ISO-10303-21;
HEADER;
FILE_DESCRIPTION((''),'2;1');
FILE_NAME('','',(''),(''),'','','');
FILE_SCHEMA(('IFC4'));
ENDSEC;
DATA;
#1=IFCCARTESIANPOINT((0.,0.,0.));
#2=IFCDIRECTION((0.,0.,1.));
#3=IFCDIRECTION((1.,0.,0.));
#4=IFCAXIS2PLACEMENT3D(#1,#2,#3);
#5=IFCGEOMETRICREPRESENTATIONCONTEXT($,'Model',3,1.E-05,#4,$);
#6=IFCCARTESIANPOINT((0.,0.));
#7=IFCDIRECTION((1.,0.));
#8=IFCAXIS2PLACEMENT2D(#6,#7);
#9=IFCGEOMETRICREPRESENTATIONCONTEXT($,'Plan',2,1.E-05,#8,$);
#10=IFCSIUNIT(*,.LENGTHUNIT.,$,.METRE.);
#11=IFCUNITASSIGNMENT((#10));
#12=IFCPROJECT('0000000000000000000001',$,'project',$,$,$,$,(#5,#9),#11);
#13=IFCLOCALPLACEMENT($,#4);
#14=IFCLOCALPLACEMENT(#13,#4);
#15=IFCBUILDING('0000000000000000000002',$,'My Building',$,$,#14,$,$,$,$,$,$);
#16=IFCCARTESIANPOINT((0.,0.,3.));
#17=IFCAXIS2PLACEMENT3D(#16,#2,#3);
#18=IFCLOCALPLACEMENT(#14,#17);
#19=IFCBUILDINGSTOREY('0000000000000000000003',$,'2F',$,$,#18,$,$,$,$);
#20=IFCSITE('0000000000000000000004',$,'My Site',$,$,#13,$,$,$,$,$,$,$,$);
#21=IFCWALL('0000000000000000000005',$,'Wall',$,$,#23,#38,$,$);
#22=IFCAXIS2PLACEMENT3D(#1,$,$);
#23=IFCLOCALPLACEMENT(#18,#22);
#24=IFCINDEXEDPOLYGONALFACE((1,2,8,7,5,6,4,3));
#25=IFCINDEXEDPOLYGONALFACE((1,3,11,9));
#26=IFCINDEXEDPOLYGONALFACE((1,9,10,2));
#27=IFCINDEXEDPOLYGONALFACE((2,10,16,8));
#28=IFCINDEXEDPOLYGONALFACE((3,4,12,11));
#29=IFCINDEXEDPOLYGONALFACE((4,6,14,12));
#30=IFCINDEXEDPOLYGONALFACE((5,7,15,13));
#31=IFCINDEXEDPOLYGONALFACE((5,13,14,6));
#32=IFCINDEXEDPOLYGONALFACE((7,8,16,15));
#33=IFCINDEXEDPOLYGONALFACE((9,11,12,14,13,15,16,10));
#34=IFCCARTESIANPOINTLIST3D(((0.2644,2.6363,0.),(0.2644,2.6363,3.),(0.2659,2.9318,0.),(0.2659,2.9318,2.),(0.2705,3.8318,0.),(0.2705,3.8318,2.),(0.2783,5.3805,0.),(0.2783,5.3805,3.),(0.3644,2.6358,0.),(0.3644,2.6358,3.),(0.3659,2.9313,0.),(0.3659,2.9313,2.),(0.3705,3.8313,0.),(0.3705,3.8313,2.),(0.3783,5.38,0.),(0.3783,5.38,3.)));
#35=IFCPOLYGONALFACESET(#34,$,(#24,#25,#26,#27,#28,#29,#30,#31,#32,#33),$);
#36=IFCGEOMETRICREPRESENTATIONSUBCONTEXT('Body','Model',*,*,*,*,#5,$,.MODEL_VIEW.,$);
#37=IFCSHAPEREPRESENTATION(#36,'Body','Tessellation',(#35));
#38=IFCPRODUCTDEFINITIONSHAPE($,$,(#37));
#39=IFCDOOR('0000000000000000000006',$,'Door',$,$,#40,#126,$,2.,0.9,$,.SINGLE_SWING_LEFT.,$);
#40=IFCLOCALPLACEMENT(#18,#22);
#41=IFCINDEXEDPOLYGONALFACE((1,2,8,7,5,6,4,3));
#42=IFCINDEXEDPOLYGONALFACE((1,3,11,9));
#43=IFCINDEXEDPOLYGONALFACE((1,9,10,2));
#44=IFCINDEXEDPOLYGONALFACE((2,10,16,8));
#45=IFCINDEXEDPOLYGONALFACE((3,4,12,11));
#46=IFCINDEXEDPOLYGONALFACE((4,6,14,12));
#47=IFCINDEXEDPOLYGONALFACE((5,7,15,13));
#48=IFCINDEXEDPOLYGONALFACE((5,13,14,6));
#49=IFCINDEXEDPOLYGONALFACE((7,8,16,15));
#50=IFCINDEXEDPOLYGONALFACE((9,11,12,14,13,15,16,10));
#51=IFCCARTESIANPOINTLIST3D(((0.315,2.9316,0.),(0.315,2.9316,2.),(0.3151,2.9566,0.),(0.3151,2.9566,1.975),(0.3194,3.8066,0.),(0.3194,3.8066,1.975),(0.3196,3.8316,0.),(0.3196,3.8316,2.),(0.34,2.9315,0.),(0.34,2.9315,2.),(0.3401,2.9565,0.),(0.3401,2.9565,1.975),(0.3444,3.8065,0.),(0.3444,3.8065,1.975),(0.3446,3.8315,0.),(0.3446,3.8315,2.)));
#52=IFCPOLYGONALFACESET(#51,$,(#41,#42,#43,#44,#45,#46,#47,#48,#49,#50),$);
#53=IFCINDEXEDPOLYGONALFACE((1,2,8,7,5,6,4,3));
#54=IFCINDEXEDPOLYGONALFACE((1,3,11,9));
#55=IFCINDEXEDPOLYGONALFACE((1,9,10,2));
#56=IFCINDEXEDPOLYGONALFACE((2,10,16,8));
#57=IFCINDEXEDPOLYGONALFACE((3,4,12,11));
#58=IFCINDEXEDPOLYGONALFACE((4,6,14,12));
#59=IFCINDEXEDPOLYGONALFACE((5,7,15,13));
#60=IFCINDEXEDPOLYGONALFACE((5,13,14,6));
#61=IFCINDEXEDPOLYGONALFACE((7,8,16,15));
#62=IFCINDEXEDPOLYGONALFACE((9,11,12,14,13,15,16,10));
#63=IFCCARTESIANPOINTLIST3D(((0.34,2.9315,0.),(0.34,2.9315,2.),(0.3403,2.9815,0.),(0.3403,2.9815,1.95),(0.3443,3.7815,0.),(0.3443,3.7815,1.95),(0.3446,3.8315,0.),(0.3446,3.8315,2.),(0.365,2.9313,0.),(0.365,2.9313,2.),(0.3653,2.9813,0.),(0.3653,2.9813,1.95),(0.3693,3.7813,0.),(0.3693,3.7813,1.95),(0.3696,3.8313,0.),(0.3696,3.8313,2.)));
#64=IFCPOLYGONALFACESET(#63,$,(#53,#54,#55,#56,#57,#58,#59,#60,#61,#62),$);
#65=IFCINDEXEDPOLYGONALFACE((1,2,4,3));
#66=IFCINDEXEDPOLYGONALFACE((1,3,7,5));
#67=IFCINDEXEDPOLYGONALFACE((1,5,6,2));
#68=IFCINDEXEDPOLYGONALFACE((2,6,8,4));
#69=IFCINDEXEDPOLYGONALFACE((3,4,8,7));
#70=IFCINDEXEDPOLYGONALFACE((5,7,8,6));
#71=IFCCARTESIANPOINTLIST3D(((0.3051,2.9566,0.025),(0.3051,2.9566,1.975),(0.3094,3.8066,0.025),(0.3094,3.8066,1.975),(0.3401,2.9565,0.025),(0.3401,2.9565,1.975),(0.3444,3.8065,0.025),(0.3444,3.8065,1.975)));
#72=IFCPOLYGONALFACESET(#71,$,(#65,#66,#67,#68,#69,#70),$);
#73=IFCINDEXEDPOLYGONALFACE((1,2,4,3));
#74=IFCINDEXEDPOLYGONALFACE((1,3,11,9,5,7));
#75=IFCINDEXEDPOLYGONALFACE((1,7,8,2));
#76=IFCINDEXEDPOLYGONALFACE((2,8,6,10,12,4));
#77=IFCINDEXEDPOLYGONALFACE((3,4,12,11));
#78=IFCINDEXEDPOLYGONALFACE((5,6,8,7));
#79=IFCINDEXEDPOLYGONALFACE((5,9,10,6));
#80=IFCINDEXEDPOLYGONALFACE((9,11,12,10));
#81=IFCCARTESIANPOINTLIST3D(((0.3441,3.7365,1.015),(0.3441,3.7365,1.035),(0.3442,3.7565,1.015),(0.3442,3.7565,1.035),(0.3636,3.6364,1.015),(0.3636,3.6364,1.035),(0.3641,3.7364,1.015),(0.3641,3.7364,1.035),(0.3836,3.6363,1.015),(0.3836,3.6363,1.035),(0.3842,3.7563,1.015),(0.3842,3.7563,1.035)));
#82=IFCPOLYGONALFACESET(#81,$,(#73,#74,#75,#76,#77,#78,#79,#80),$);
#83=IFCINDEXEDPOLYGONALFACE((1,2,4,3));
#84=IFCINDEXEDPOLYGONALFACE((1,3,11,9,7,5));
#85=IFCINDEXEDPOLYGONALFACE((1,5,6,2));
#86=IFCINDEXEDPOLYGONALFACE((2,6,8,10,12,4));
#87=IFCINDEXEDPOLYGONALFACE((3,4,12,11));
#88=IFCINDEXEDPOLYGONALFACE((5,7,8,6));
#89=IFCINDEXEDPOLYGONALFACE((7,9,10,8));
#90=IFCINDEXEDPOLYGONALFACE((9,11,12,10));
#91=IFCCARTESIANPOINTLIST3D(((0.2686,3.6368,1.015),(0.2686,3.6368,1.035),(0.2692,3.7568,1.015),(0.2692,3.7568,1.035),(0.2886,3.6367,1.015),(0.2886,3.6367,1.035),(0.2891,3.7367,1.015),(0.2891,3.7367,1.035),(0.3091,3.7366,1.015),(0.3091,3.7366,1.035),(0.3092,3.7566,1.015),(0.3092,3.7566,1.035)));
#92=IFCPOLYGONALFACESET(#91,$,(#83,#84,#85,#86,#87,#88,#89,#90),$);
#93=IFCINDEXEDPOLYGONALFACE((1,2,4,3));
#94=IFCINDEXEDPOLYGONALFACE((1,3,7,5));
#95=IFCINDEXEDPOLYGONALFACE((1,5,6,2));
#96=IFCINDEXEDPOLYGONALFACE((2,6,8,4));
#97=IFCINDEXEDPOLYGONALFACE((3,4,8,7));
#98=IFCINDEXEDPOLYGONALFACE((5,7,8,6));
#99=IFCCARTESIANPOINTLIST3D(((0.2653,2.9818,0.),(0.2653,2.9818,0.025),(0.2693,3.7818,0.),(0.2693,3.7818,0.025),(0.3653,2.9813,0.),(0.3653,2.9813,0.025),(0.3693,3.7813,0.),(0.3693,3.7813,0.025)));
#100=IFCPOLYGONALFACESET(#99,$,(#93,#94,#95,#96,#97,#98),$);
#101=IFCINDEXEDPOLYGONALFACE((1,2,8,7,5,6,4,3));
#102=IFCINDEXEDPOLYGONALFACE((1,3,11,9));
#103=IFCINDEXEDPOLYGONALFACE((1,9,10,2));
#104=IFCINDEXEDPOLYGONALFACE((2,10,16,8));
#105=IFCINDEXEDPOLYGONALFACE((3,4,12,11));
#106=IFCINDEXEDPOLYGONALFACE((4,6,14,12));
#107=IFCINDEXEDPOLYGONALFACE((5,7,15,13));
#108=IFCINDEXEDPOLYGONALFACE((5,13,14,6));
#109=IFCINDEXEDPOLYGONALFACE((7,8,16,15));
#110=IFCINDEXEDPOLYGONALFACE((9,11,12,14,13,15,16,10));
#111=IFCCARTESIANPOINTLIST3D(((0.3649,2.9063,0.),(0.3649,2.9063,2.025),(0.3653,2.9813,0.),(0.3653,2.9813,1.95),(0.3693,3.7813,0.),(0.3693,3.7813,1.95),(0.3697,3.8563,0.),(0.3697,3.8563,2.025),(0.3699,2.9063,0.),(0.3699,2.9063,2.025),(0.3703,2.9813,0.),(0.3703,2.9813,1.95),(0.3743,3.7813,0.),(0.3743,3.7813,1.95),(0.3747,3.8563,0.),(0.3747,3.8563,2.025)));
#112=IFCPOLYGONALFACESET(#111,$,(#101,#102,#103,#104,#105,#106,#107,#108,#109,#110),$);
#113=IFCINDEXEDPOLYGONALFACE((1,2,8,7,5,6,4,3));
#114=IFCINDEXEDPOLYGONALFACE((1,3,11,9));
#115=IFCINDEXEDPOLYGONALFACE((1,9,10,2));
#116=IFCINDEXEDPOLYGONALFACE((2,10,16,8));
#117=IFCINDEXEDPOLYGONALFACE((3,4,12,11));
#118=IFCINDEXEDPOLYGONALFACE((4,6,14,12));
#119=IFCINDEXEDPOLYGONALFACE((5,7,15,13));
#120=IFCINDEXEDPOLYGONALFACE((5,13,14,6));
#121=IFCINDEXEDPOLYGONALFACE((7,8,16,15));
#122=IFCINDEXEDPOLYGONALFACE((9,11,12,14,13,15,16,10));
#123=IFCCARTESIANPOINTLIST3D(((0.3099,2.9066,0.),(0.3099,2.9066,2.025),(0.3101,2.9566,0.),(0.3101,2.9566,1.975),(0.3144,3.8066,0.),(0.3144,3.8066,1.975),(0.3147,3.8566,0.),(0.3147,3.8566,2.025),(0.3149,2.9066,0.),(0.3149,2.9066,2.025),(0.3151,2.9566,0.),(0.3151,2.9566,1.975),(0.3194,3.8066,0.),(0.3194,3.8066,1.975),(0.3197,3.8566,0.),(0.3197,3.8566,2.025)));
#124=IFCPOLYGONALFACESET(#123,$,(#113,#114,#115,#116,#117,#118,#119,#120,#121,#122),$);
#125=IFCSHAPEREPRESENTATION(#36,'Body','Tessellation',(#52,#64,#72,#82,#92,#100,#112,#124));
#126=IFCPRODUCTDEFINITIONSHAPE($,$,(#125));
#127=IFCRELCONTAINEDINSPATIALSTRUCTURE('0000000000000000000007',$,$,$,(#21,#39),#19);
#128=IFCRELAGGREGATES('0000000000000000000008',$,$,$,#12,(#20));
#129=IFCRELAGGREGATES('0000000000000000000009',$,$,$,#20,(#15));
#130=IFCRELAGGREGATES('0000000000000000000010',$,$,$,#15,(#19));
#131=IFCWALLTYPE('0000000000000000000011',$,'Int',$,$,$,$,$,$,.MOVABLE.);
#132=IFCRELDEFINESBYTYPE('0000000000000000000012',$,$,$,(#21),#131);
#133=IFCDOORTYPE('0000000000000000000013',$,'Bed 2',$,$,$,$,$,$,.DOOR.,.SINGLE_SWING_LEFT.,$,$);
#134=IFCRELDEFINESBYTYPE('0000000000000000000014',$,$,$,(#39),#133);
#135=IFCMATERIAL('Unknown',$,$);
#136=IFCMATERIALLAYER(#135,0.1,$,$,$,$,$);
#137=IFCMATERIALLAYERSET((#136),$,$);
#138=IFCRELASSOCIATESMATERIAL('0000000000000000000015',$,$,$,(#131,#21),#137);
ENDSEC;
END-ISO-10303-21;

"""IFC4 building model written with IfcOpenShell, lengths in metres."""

from ifc_helpers import new_model, entity, si_unit, frame, origin_with_axes, origin_2d_with_axis, place, context, subcontext, project, spatial, line, indexed_curve, outline, extrude, shape, source, transform, mapped, material, layer, layer_set, layer_usage, type_object, type_shapes, element, fill, save


model = new_model("IFC4")

# Units and contexts
model_context = context("Model", 3, precision=1e-05, world=origin_with_axes())
plan_context = context("Plan", 2, precision=1e-05, world=origin_2d_with_axis())
body_context_1 = subcontext(model_context, "Body", "Model", "MODEL_VIEW")
body_context_2 = subcontext(plan_context, "Body", "Plan", "PLAN_VIEW")
ifc_project = project(units=[si_unit("LENGTHUNIT", "METRE")], contexts=[model_context, plan_context])

# Site, building, storey
site_placement = place(None, origin_with_axes())
site = spatial("IfcSite", under=ifc_project, at=site_placement, Name="My Site")
building_placement = place(site_placement, origin_with_axes())
building = spatial("IfcBuilding", under=site, at=building_placement, Name="My Building")
storey_placement = place(building_placement, frame((0.0, 0.0, 3.0), z_axis=(0.0, 0.0, 1.0), x_axis=(1.0, 0.0, 0.0)))
storey = spatial("IfcBuildingStorey", under=building, at=storey_placement, Name="2F")

# Shared definitions
ifc_material = material(Name="Unknown")

# Shared definitions
ifc_layer_1 = layer(ifc_material, 0.1)
ifc_layer_set_1 = layer_set([ifc_layer_1])
wall_type_1 = type_object("IfcWallType", Name="Int", PredefinedType="MOVABLE", material=ifc_layer_set_1)

# Wall, opening, door
ifc_layer_usage_1 = layer_usage(ifc_layer_set_1, "AXIS2", "POSITIVE", 0.0)
wall_1_placement = place(storey_placement, frame((0.3644, 2.6358, 0.0), z_axis=(0.0, 0.0, 1.0), x_axis=(0.005081, 0.999987, 0.0)))
wall_1 = element("IfcWall", 1, at=wall_1_placement, inside=storey, type_object=wall_type_1, material=ifc_layer_usage_1, Name="Wall", context=body_context_1, shape_type="SweptSolid", body=[
    extrude(outline(indexed_curve([(0.0, 0.0), (0.0, 0.1), (2.7442, 0.1), (2.7442, 0.0)], segments=[line(1, 2, 3, 4, 1)])), origin_with_axes(), (0.0, 0.0, 1.0), 3.0),
])
shared_shape_1 = source(origin_with_axes(), body_context_1, "Body", "SweptSolid", [
    extrude(outline(indexed_curve([(0.0, 0.0), (0.9, 0.0), (0.9, 2.0), (0.0, 2.0)], segments=[line(1, 2, 3, 4, 1)])), frame((0.0, -0.6, 0.0), z_axis=(0.0, -1.0, 0.0), x_axis=(1.0, 0.0, 0.0)), (0.0, 0.0, -1.0), 1.2),
])
opening_1_placement = place(wall_1_placement, frame((0.2956, 0.0009, 0.0), z_axis=(0.0, 0.0, 1.0), x_axis=(1.0, 0.000001, 0.0)))
opening_1 = element("IfcOpeningElement", 2, at=opening_1_placement, cuts=wall_1, PredefinedType="OPENING", context=body_context_1, shape_type="MappedRepresentation", body=[
    mapped(shared_shape_1, transform((0.0, 0.0, 0.0), x_axis=(1.0, 0.0, 0.0), y_axis=(0.0, 1.0, 0.0), z_axis=(0.0, 0.0, 1.0), scale=1.0)),
])
door_type_1 = type_object("IfcDoorType", Name="Bed 2", OperationType="SINGLE_SWING_LEFT", PredefinedType="DOOR")
shared_shape_2 = source(origin_with_axes(), body_context_1, "Body", "SweptSolid", [
    extrude(outline(indexed_curve([(0.0, 0.0), (0.0, 2.0), (0.9, 2.0), (0.9, 0.0), (0.875, 0.0), (0.875, 1.975), (0.025, 1.975), (0.025, 0.0)], segments=[line(1, 2, 3, 4, 5, 6, 7, 8, 1)])), frame((0.0, 0.025, 0.0), z_axis=(0.0, -1.0, 0.0), x_axis=(1.0, 0.0, 0.0)), (0.0, 0.0, -1.0), 0.025),
    extrude(outline(indexed_curve([(0.0, 0.0), (0.0, 2.0), (0.9, 2.0), (0.9, 0.0), (0.85, 0.0), (0.85, 1.95), (0.05, 1.95), (0.05, 0.0)], segments=[line(1, 2, 3, 4, 5, 6, 7, 8, 1)])), frame((0.0, 0.0, 0.0), z_axis=(0.0, -1.0, 0.0), x_axis=(1.0, 0.0, 0.0)), (0.0, 0.0, -1.0), 0.025),
    extrude(outline(indexed_curve([(0.0, 0.0), (0.85, 0.0), (0.85, 0.035), (0.0, 0.035)], segments=[line(1, 2, 3, 4, 1)])), frame((0.025, 0.025, 0.025), z_axis=(0.0, 0.0, 1.0), x_axis=(1.0, 0.0, 0.0)), (0.0, 0.0, 1.0), 1.95),
    extrude(outline(indexed_curve([(0.0, 0.0), (0.0, -0.04), (-0.12, -0.04), (-0.12, -0.02), (-0.02, -0.02), (-0.02, 0.0)], segments=[line(1, 2, 3, 4, 5, 6, 1)])), frame((0.825, 0.025, 1.015), z_axis=(0.0, 0.0, 1.0), x_axis=(1.0, 0.0, 0.0)), (0.0, 0.0, 1.0), 0.02),
    extrude(outline(indexed_curve([(0.0, 0.0), (0.0, 0.04), (-0.12, 0.04), (-0.12, 0.02), (-0.02, 0.02), (-0.02, 0.0)], segments=[line(1, 2, 3, 4, 5, 6, 1)])), frame((0.825, 0.06, 1.015), z_axis=(0.0, 0.0, 1.0), x_axis=(1.0, 0.0, 0.0)), (0.0, 0.0, 1.0), 0.02),
    extrude(outline(indexed_curve([(0.0, 0.0), (0.8, 0.0), (0.8, 0.1), (0.0, 0.1)], segments=[line(1, 2, 3, 4, 1)])), frame((0.05, 0.0, 0.0), z_axis=(0.0, 0.0, 1.0), x_axis=(1.0, 0.0, 0.0)), (0.0, 0.0, 1.0), 0.025),
    extrude(outline(indexed_curve([(0.0, 0.0), (0.0, 2.025), (0.95, 2.025), (0.95, 0.0), (0.875, 0.0), (0.875, 1.95), (0.075, 1.95), (0.075, 0.0)], segments=[line(1, 2, 3, 4, 5, 6, 7, 8, 1)])), frame((-0.025, -0.005, 0.0), z_axis=(0.0, -1.0, 0.0), x_axis=(1.0, 0.0, 0.0)), (0.0, 0.0, -1.0), 0.005),
    extrude(outline(indexed_curve([(0.0, 0.0), (0.0, 2.025), (0.95, 2.025), (0.95, 0.0), (0.9, 0.0), (0.9, 1.975), (0.05, 1.975), (0.05, 0.0)], segments=[line(1, 2, 3, 4, 5, 6, 7, 8, 1)])), frame((-0.025, 0.05, 0.0), z_axis=(0.0, -1.0, 0.0), x_axis=(1.0, 0.0, 0.0)), (0.0, 0.0, -1.0), 0.005),
])
shared_shape_3 = source(origin_with_axes(), body_context_2, "Body", "Curve2D", [
    entity("IfcIndexedPolyCurve", entity("IfcCartesianPointList2D", [[0.0, 0.0], [0.0, 0.05], [0.025, 0.05], [0.025, 0.025], [0.05, 0.025], [0.05, 0.0]]), [entity("IfcLineIndex", [1, 2, 3, 4, 5, 6, 1])]),
    entity("IfcIndexedPolyCurve", entity("IfcCartesianPointList2D", [[0.9, 0.0], [0.9, 0.05], [0.875, 0.05], [0.875, 0.025], [0.85, 0.025], [0.85, 0.0]]), [entity("IfcLineIndex", [1, 2, 3, 4, 5, 6, 1])]),
    entity("IfcTrimmedCurve", entity("IfcEllipse", entity("IfcAxis2Placement2D", entity("IfcCartesianPoint", [0.06, 0.05]), entity("IfcDirection", [1.0, 0.0])), 0.815, 0.85), [entity("IfcCartesianPoint", [0.875, 0.05])], [entity("IfcCartesianPoint", [0.06, 0.9])], True, "CARTESIAN"),
    entity("IfcIndexedPolyCurve", entity("IfcCartesianPointList2D", [[0.025, 0.05], [0.06, 0.05], [0.06, 0.9], [0.025, 0.9]]), [entity("IfcLineIndex", [1, 2, 3, 4, 1])]),
])
type_shapes(door_type_1, [shared_shape_2, shared_shape_3])
door_1_placement = place(opening_1_placement, frame((0.0, 0.0, 0.0), z_axis=(0.0, 0.0, 1.0), x_axis=(1.0, 0.0, 0.0)))
door_1 = element("IfcDoor", 3, at=door_1_placement, inside=storey, type_object=door_type_1, Name="Door", OperationType="SINGLE_SWING_LEFT", OverallHeight=2.0, OverallWidth=0.9, shapes=[
    shape(body_context_1, "Body", "MappedRepresentation", [mapped(shared_shape_2, transform((0.0, 0.0, 0.0), x_axis=(1.0, 0.0, 0.0), y_axis=(0.0, 1.0, 0.0), z_axis=(0.0, 0.0, 1.0), scale=1.0))]),
    shape(body_context_2, "Body", "MappedRepresentation", [mapped(shared_shape_3, transform((0.0, 0.0, 0.0), x_axis=(1.0, 0.0, 0.0), y_axis=(0.0, 1.0, 0.0), z_axis=(0.0, 0.0, 1.0), scale=1.0))]),
])
fill(opening_1, door_1)

save(model, "model.ifc")
